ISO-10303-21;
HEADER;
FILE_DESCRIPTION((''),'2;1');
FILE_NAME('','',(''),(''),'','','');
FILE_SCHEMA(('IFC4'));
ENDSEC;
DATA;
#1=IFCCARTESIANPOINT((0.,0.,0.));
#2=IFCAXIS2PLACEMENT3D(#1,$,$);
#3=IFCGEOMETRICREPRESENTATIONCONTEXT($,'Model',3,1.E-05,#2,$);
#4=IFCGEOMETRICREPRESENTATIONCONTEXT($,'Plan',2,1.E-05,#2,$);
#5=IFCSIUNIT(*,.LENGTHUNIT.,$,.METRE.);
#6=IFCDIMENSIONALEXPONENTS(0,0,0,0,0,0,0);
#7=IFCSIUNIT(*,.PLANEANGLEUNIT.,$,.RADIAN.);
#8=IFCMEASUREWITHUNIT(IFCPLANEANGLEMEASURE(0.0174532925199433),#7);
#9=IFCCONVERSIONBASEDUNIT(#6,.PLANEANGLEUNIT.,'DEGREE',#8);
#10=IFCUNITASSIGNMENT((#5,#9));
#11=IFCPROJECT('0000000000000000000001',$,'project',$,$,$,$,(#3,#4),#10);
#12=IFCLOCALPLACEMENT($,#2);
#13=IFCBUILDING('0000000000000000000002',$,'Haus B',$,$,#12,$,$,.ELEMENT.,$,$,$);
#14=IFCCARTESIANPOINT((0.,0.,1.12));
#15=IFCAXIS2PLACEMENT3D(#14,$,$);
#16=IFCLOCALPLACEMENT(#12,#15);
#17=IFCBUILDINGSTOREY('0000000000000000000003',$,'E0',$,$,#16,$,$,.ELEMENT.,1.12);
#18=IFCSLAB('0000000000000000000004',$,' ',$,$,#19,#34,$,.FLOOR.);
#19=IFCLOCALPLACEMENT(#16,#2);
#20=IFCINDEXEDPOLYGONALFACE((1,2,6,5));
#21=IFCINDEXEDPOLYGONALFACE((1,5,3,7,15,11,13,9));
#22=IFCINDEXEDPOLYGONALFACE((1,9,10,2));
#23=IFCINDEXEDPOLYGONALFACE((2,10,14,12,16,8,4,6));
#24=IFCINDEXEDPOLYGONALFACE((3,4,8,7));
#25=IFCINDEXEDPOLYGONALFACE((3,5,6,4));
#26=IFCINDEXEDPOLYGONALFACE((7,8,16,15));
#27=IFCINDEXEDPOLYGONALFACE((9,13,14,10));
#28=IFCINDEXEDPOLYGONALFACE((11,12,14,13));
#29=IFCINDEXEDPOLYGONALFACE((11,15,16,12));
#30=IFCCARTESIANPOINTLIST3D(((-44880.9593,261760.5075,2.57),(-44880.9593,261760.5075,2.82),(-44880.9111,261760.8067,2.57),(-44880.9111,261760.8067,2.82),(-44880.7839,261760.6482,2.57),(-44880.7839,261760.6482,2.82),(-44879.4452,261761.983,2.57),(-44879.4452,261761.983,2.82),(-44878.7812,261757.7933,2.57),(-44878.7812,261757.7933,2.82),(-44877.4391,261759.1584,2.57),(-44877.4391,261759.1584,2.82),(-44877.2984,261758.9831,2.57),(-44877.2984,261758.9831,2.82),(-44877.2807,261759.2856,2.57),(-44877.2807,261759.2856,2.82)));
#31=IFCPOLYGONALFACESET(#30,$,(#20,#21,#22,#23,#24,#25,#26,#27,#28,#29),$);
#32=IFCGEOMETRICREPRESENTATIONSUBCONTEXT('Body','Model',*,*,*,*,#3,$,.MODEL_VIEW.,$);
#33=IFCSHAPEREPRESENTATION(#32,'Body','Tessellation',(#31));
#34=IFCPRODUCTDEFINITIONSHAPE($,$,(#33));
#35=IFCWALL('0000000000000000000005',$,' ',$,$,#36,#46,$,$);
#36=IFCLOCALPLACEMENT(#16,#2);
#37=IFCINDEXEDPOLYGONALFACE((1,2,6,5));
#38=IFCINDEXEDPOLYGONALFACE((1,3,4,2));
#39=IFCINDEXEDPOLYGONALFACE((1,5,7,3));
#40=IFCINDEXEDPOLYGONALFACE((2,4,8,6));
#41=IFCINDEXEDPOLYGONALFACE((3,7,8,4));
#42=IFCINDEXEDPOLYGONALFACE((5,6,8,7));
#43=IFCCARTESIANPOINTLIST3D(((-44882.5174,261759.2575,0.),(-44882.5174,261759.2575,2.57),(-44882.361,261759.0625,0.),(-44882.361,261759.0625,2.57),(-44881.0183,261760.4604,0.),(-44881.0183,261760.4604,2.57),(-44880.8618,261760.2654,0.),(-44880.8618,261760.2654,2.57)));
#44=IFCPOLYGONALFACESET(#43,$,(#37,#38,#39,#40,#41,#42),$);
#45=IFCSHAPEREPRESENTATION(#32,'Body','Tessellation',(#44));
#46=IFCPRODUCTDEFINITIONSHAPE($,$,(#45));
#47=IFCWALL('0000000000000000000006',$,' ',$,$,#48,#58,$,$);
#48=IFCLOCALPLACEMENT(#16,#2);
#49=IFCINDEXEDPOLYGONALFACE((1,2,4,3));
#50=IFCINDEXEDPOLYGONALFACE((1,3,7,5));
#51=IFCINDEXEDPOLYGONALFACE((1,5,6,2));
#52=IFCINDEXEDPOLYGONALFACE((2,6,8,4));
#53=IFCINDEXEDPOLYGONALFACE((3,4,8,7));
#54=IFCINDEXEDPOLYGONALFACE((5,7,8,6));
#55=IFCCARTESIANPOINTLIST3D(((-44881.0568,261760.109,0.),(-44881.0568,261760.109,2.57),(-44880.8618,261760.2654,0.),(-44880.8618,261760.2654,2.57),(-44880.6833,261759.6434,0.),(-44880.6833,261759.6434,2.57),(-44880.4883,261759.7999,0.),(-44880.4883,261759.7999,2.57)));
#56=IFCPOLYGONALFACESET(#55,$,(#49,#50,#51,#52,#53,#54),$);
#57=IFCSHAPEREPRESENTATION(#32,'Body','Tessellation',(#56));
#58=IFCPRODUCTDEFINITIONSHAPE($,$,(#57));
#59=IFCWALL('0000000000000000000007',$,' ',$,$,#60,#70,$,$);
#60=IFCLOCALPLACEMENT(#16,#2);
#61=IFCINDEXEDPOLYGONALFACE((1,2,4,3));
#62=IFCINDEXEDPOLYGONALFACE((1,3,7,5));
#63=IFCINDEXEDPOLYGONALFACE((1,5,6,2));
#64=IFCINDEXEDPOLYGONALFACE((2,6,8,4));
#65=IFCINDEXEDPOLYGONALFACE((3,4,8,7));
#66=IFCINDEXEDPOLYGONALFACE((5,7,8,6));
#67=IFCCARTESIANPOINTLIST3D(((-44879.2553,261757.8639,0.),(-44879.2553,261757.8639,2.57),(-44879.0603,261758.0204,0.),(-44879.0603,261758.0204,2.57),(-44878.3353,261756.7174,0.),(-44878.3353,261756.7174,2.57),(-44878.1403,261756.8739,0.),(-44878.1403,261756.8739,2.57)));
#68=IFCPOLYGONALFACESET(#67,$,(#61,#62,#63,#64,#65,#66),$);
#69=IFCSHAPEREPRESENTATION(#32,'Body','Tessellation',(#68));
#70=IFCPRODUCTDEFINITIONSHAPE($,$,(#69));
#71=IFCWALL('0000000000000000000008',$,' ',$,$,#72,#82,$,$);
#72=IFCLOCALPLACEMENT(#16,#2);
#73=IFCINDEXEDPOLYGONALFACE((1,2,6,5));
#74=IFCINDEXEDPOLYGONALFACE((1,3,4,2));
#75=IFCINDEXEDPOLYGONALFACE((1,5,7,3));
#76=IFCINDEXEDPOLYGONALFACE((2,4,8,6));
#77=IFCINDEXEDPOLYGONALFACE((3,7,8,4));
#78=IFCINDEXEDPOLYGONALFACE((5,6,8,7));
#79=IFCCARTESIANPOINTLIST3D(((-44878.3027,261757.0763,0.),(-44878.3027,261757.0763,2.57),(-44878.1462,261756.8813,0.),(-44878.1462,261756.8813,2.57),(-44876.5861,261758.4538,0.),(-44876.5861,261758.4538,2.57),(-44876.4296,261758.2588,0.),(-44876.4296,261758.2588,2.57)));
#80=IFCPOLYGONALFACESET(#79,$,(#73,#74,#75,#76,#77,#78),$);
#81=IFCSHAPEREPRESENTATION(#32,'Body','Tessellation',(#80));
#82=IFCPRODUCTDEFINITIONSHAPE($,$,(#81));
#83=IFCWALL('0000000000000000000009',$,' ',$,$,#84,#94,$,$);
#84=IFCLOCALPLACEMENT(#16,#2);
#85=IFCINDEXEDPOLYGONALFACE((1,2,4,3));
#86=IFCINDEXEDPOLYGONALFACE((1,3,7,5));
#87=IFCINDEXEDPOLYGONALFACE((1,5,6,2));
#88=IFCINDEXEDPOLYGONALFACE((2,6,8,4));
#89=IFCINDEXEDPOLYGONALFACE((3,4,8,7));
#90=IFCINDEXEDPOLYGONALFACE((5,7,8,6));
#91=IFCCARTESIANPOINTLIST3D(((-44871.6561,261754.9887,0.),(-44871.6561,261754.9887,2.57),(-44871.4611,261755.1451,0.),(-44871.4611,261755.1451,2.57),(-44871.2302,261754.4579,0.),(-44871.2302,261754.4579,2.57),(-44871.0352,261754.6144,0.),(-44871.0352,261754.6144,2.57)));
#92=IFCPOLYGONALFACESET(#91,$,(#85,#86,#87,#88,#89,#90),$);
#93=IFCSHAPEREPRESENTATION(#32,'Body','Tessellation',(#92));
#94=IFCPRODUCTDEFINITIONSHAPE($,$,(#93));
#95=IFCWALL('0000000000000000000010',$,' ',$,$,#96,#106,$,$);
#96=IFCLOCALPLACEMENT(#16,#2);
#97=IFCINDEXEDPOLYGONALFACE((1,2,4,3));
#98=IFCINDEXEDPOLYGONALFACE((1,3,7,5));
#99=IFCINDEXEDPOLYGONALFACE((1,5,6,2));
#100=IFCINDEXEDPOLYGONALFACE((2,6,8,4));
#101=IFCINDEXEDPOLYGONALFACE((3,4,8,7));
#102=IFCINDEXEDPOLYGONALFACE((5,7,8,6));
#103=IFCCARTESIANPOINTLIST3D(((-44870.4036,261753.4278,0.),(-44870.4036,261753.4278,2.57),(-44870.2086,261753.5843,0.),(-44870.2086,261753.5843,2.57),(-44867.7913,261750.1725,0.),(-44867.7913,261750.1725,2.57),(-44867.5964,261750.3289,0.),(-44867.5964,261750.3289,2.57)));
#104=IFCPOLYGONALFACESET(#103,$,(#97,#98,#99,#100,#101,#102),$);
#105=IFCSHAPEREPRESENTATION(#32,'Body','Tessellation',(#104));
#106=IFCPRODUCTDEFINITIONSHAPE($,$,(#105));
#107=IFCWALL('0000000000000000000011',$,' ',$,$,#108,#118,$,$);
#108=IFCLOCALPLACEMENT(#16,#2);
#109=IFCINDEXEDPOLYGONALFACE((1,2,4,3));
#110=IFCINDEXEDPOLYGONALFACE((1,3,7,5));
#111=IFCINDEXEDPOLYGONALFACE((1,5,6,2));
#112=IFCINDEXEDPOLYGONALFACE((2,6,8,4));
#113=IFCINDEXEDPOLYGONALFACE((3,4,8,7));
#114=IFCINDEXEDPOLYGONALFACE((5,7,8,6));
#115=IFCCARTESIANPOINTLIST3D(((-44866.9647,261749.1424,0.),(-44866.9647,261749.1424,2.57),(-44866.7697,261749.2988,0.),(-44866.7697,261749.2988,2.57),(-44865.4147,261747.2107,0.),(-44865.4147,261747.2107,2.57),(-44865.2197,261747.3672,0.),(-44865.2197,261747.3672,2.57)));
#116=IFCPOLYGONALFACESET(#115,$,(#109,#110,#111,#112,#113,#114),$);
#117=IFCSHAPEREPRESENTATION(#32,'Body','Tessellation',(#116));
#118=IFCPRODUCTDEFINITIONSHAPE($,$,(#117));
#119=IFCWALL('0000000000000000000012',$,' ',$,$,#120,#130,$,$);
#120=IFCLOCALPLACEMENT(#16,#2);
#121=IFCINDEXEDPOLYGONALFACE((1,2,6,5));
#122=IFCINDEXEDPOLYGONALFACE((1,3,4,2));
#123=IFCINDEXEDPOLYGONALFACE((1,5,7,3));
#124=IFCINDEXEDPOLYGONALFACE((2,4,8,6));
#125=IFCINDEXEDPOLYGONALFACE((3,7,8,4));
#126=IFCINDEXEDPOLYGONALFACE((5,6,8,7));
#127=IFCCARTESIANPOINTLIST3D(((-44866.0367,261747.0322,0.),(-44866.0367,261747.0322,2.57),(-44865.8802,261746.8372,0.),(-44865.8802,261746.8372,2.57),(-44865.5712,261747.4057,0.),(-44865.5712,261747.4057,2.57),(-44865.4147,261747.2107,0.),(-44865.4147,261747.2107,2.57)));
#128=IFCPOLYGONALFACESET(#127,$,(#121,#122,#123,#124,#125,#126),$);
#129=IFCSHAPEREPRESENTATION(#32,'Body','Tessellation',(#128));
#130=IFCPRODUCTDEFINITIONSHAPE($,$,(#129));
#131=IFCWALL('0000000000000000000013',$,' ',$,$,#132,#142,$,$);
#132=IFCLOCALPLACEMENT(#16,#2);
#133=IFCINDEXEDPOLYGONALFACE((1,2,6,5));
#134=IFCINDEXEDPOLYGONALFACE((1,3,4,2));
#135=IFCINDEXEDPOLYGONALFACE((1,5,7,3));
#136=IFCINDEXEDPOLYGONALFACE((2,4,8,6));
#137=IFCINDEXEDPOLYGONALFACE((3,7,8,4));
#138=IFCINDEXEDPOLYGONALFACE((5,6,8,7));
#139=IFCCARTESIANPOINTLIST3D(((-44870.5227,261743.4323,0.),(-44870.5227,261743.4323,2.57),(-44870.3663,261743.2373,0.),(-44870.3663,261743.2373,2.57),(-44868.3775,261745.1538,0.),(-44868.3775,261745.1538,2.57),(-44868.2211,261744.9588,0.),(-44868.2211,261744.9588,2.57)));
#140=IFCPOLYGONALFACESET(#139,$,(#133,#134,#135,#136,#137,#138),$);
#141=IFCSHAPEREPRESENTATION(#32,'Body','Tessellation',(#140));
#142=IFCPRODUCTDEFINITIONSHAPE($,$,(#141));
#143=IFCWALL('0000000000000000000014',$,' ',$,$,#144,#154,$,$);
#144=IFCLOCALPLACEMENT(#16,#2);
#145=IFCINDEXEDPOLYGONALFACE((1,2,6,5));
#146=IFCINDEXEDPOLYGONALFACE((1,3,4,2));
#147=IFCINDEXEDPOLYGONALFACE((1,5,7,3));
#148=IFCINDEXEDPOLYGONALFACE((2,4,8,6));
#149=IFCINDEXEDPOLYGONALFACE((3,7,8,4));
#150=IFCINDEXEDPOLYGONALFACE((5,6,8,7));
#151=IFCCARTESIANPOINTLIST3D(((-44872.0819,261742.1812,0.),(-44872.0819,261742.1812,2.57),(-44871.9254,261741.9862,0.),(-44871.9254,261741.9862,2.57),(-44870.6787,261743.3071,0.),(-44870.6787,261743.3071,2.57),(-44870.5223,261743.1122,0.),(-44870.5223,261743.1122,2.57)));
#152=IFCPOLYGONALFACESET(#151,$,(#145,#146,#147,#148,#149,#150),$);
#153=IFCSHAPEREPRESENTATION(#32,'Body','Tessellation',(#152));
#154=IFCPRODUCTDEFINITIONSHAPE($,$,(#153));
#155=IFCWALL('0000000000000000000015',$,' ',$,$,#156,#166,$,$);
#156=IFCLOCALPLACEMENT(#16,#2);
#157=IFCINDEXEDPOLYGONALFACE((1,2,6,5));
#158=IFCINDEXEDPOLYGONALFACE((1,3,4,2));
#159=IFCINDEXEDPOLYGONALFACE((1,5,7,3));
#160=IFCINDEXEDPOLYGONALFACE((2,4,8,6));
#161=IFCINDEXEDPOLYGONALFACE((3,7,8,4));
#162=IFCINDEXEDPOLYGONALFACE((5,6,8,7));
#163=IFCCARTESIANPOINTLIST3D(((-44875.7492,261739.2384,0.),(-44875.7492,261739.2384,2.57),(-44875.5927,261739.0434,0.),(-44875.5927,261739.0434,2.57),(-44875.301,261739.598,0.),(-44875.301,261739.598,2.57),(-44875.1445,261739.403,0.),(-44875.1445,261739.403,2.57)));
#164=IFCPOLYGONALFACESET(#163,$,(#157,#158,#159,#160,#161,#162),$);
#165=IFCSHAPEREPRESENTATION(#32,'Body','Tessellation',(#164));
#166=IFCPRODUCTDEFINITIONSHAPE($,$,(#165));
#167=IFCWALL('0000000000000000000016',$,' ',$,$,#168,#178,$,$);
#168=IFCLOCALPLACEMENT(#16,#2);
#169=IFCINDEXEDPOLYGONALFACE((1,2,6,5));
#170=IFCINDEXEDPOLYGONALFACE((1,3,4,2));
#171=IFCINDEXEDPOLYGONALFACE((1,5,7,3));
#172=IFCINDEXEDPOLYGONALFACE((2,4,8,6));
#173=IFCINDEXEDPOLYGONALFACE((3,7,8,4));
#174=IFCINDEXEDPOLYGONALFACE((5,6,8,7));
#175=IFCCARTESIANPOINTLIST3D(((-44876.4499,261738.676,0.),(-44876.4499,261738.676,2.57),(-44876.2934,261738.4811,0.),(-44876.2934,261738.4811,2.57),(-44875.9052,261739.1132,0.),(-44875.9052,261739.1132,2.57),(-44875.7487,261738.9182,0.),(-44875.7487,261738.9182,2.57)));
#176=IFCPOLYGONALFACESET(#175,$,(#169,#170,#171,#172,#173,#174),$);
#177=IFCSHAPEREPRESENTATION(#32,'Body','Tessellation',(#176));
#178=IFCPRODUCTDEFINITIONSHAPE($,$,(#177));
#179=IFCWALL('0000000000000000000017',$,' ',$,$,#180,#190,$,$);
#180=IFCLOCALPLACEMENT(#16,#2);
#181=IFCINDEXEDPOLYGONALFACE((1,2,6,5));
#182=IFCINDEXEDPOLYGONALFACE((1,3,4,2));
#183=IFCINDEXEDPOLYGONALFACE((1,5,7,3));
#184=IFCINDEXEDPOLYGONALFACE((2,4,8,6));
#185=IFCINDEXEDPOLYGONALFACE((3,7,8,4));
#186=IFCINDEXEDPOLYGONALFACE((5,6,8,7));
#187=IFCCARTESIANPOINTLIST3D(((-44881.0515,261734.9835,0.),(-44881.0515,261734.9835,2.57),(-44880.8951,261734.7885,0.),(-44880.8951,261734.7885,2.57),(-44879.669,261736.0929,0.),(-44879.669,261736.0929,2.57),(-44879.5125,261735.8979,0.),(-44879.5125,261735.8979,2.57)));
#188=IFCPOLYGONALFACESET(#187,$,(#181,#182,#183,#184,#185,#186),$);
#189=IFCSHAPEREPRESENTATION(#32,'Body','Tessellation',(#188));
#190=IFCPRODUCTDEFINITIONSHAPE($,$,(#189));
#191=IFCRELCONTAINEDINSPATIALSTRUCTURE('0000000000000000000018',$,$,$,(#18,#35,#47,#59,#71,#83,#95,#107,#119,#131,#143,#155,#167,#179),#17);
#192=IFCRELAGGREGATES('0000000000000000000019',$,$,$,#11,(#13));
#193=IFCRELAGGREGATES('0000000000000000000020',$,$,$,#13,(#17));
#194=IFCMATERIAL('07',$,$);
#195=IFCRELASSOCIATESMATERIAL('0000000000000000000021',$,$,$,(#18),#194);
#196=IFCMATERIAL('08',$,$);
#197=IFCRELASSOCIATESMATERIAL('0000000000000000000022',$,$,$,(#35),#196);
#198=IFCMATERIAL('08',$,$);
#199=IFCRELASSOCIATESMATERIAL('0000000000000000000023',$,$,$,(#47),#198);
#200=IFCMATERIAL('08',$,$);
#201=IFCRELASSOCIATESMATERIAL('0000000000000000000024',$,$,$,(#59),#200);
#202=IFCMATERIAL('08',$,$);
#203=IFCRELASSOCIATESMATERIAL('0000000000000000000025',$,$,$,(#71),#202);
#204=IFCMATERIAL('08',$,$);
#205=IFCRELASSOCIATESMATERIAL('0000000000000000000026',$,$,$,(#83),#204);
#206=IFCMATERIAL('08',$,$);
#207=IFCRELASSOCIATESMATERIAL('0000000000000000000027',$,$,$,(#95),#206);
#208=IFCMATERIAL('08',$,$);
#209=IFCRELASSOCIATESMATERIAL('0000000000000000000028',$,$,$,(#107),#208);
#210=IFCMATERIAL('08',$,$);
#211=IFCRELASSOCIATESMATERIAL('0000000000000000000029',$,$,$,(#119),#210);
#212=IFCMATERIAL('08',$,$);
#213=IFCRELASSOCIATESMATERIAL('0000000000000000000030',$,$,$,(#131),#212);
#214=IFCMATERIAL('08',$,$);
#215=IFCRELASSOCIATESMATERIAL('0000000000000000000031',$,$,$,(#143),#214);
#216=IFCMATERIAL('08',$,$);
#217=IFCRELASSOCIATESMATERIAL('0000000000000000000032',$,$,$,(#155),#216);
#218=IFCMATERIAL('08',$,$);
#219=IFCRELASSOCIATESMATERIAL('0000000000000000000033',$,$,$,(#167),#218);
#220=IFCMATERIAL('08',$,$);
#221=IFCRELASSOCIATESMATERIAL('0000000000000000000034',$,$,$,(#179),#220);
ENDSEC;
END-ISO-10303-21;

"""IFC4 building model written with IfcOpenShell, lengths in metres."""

from ifc_helpers import new_model, entity, si_unit, converted_unit, frame, frame_2d, origin, origin_with_axes, place, context, subcontext, project, spatial, polyline, rectangle, outline, extrude, material, element, save


model = new_model("IFC4")

# Units and contexts
model_context = context("Model", 3, precision=1e-05, world=origin())
plan_context = context("Plan", 2, precision=1e-05, world=origin())
body_context = subcontext(model_context, "Body", "Model", "MODEL_VIEW")
ifc_project = project(units=[si_unit("LENGTHUNIT", "METRE"), converted_unit("PLANEANGLEUNIT", "DEGREE", entity("IfcPlaneAngleMeasure", 0.0174532925199433), si_unit("PLANEANGLEUNIT", "RADIAN"), dimensions=[0, 0, 0, 0, 0, 0, 0])], contexts=[model_context, plan_context])

# Building, storey
building_placement = place(None, origin())
building = spatial("IfcBuilding", under=ifc_project, at=building_placement, Name="Haus B", CompositionType="ELEMENT")
storey_placement = place(building_placement, frame((0.0, 0.0, 1.12)))
storey = spatial("IfcBuildingStorey", under=building, at=storey_placement, Name="E0", CompositionType="ELEMENT", Elevation=1.12)

# Slab
ifc_material_1 = material(Name="07")
slab_placement = place(storey_placement, frame((-44880.9593, 261757.7933, 2.57)))
element("IfcSlab", 1, at=slab_placement, inside=storey, material=ifc_material_1, Name=" ", PredefinedType="FLOOR", context=body_context, shape_type="SweptSolid", body=[
    extrude(outline(polyline([(0.0, 2.7142), (2.1781, 0.0), (3.6608, 1.1898), (3.5201, 1.3652), (3.6786, 1.4923), (1.5141, 4.1897), (0.0482, 3.0134), (0.1753, 2.8549), (0.0, 2.7142)])), origin_with_axes(), (0.0, 0.0, 1.0), 0.25),
])

# Walls
ifc_material_2 = material(Name="08")
wall_1_placement = place(storey_placement, frame((-44882.361, 261759.0625, 0.0), z_axis=(0.0, 0.0, 1.0), x_axis=(0.779935, 0.625861, 0.0)))
element("IfcWall", 2, at=wall_1_placement, inside=storey, material=ifc_material_2, Name=" ", context=body_context, shape_type="SweptSolid", body=[
    extrude(rectangle(XDim=1.9221, YDim=0.25, at=frame_2d((0.9611, 0.125), x_axis=(1.0, 0.0))), origin_with_axes(), (0.0, 0.0, 1.0), 2.57),
])
ifc_material_3 = material(Name="08")
wall_2_placement = place(storey_placement, frame((-44881.0568, 261760.109, 0.0), z_axis=(0.0, 0.0, 1.0), x_axis=(0.625861, -0.779935, 0.0)))
element("IfcWall", 3, at=wall_2_placement, inside=storey, material=ifc_material_3, Name=" ", context=body_context, shape_type="SweptSolid", body=[
    extrude(rectangle(XDim=0.5969, YDim=0.25, at=frame_2d((0.2984, 0.125), x_axis=(1.0, 0.0))), origin_with_axes(), (0.0, 0.0, 1.0), 2.57),
])
ifc_material_4 = material(Name="08")
wall_3_placement = place(storey_placement, frame((-44879.2553, 261757.8639, 0.0), z_axis=(0.0, 0.0, 1.0), x_axis=(0.625861, -0.779935, 0.0)))
element("IfcWall", 4, at=wall_3_placement, inside=storey, material=ifc_material_4, Name=" ", context=body_context, shape_type="SweptSolid", body=[
    extrude(rectangle(XDim=1.47, YDim=0.25, at=frame_2d((0.735, 0.125), x_axis=(1.0, 0.0))), origin_with_axes(), (0.0, 0.0, 1.0), 2.57),
])
ifc_material_5 = material(Name="08")
wall_4_placement = place(storey_placement, frame((-44878.1462, 261756.8813, 0.0), z_axis=(0.0, 0.0, 1.0), x_axis=(0.779935, 0.625861, 0.0)))
element("IfcWall", 5, at=wall_4_placement, inside=storey, material=ifc_material_5, Name=" ", context=body_context, shape_type="SweptSolid", body=[
    extrude(rectangle(XDim=2.201, YDim=0.25, at=frame_2d((1.1005, 0.125), x_axis=(1.0, 0.0))), origin_with_axes(), (0.0, 0.0, 1.0), 2.57),
])
ifc_material_6 = material(Name="08")
wall_5_placement = place(storey_placement, frame((-44871.6561, 261754.9887, 0.0), z_axis=(0.0, 0.0, 1.0), x_axis=(0.625861, -0.779935, 0.0)))
element("IfcWall", 6, at=wall_5_placement, inside=storey, material=ifc_material_6, Name=" ", context=body_context, shape_type="SweptSolid", body=[
    extrude(rectangle(XDim=0.6805, YDim=0.25, at=frame_2d((0.3402, 0.125), x_axis=(1.0, 0.0))), origin_with_axes(), (0.0, 0.0, 1.0), 2.57),
])
ifc_material_7 = material(Name="08")
wall_6_placement = place(storey_placement, frame((-44870.4036, 261753.4278, 0.0), z_axis=(0.0, 0.0, 1.0), x_axis=(0.625861, -0.779935, 0.0)))
element("IfcWall", 7, at=wall_6_placement, inside=storey, material=ifc_material_7, Name=" ", context=body_context, shape_type="SweptSolid", body=[
    extrude(rectangle(XDim=4.1739, YDim=0.25, at=frame_2d((2.087, 0.125), x_axis=(1.0, 0.0))), origin_with_axes(), (0.0, 0.0, 1.0), 2.57),
])
ifc_material_8 = material(Name="08")
wall_7_placement = place(storey_placement, frame((-44866.9647, 261749.1424, 0.0), z_axis=(0.0, 0.0, 1.0), x_axis=(0.625861, -0.779935, 0.0)))
element("IfcWall", 8, at=wall_7_placement, inside=storey, material=ifc_material_8, Name=" ", context=body_context, shape_type="SweptSolid", body=[
    extrude(rectangle(XDim=2.4766, YDim=0.25, at=frame_2d((1.2383, 0.125), x_axis=(1.0, 0.0))), origin_with_axes(), (0.0, 0.0, 1.0), 2.57),
])
ifc_material_9 = material(Name="08")
wall_8_placement = place(storey_placement, frame((-44865.5712, 261747.4057, 0.0), z_axis=(0.0, 0.0, 1.0), x_axis=(-0.779935, -0.625861, 0.0)))
element("IfcWall", 9, at=wall_8_placement, inside=storey, material=ifc_material_9, Name=" ", context=body_context, shape_type="SweptSolid", body=[
    extrude(rectangle(XDim=0.5969, YDim=0.25, at=frame_2d((0.2984, 0.125), x_axis=(1.0, 0.0))), origin_with_axes(), (0.0, 0.0, 1.0), 2.57),
])
ifc_material_10 = material(Name="08")
wall_9_placement = place(storey_placement, frame((-44868.3775, 261745.1538, 0.0), z_axis=(0.0, 0.0, 1.0), x_axis=(-0.779935, -0.625861, 0.0)))
element("IfcWall", 10, at=wall_9_placement, inside=storey, material=ifc_material_10, Name=" ", context=body_context, shape_type="SweptSolid", body=[
    extrude(rectangle(XDim=2.7505, YDim=0.25, at=frame_2d((1.3753, 0.125), x_axis=(1.0, 0.0))), origin_with_axes(), (0.0, 0.0, 1.0), 2.57),
])
ifc_material_11 = material(Name="08")
wall_10_placement = place(storey_placement, frame((-44870.6787, 261743.3071, 0.0), z_axis=(0.0, 0.0, 1.0), x_axis=(-0.779935, -0.625861, 0.0)))
element("IfcWall", 11, at=wall_10_placement, inside=storey, material=ifc_material_11, Name=" ", context=body_context, shape_type="SweptSolid", body=[
    extrude(rectangle(XDim=1.7991, YDim=0.25, at=frame_2d((0.8995, 0.125), x_axis=(1.0, 0.0))), origin_with_axes(), (0.0, 0.0, 1.0), 2.57),
])
ifc_material_12 = material(Name="08")
wall_11_placement = place(storey_placement, frame((-44875.301, 261739.598, 0.0), z_axis=(0.0, 0.0, 1.0), x_axis=(-0.779935, -0.625861, 0.0)))
element("IfcWall", 12, at=wall_11_placement, inside=storey, material=ifc_material_12, Name=" ", context=body_context, shape_type="SweptSolid", body=[
    extrude(rectangle(XDim=0.5747, YDim=0.25, at=frame_2d((0.2873, 0.125), x_axis=(1.0, 0.0))), origin_with_axes(), (0.0, 0.0, 1.0), 2.57),
])
ifc_material_13 = material(Name="08")
wall_12_placement = place(storey_placement, frame((-44875.9052, 261739.1132, 0.0), z_axis=(0.0, 0.0, 1.0), x_axis=(-0.779935, -0.625861, 0.0)))
element("IfcWall", 13, at=wall_12_placement, inside=storey, material=ifc_material_13, Name=" ", context=body_context, shape_type="SweptSolid", body=[
    extrude(rectangle(XDim=0.6985, YDim=0.25, at=frame_2d((0.3492, 0.125), x_axis=(1.0, 0.0))), origin_with_axes(), (0.0, 0.0, 1.0), 2.57),
])
ifc_material_14 = material(Name="08")
wall_13_placement = place(storey_placement, frame((-44879.669, 261736.0929, 0.0), z_axis=(0.0, 0.0, 1.0), x_axis=(-0.779935, -0.625861, 0.0)))
element("IfcWall", 14, at=wall_13_placement, inside=storey, material=ifc_material_14, Name=" ", context=body_context, shape_type="SweptSolid", body=[
    extrude(rectangle(XDim=1.7727, YDim=0.25, at=frame_2d((0.8863, 0.125), x_axis=(1.0, 0.0))), origin_with_axes(), (0.0, 0.0, 1.0), 2.57),
])

save(model, "model.ifc")
